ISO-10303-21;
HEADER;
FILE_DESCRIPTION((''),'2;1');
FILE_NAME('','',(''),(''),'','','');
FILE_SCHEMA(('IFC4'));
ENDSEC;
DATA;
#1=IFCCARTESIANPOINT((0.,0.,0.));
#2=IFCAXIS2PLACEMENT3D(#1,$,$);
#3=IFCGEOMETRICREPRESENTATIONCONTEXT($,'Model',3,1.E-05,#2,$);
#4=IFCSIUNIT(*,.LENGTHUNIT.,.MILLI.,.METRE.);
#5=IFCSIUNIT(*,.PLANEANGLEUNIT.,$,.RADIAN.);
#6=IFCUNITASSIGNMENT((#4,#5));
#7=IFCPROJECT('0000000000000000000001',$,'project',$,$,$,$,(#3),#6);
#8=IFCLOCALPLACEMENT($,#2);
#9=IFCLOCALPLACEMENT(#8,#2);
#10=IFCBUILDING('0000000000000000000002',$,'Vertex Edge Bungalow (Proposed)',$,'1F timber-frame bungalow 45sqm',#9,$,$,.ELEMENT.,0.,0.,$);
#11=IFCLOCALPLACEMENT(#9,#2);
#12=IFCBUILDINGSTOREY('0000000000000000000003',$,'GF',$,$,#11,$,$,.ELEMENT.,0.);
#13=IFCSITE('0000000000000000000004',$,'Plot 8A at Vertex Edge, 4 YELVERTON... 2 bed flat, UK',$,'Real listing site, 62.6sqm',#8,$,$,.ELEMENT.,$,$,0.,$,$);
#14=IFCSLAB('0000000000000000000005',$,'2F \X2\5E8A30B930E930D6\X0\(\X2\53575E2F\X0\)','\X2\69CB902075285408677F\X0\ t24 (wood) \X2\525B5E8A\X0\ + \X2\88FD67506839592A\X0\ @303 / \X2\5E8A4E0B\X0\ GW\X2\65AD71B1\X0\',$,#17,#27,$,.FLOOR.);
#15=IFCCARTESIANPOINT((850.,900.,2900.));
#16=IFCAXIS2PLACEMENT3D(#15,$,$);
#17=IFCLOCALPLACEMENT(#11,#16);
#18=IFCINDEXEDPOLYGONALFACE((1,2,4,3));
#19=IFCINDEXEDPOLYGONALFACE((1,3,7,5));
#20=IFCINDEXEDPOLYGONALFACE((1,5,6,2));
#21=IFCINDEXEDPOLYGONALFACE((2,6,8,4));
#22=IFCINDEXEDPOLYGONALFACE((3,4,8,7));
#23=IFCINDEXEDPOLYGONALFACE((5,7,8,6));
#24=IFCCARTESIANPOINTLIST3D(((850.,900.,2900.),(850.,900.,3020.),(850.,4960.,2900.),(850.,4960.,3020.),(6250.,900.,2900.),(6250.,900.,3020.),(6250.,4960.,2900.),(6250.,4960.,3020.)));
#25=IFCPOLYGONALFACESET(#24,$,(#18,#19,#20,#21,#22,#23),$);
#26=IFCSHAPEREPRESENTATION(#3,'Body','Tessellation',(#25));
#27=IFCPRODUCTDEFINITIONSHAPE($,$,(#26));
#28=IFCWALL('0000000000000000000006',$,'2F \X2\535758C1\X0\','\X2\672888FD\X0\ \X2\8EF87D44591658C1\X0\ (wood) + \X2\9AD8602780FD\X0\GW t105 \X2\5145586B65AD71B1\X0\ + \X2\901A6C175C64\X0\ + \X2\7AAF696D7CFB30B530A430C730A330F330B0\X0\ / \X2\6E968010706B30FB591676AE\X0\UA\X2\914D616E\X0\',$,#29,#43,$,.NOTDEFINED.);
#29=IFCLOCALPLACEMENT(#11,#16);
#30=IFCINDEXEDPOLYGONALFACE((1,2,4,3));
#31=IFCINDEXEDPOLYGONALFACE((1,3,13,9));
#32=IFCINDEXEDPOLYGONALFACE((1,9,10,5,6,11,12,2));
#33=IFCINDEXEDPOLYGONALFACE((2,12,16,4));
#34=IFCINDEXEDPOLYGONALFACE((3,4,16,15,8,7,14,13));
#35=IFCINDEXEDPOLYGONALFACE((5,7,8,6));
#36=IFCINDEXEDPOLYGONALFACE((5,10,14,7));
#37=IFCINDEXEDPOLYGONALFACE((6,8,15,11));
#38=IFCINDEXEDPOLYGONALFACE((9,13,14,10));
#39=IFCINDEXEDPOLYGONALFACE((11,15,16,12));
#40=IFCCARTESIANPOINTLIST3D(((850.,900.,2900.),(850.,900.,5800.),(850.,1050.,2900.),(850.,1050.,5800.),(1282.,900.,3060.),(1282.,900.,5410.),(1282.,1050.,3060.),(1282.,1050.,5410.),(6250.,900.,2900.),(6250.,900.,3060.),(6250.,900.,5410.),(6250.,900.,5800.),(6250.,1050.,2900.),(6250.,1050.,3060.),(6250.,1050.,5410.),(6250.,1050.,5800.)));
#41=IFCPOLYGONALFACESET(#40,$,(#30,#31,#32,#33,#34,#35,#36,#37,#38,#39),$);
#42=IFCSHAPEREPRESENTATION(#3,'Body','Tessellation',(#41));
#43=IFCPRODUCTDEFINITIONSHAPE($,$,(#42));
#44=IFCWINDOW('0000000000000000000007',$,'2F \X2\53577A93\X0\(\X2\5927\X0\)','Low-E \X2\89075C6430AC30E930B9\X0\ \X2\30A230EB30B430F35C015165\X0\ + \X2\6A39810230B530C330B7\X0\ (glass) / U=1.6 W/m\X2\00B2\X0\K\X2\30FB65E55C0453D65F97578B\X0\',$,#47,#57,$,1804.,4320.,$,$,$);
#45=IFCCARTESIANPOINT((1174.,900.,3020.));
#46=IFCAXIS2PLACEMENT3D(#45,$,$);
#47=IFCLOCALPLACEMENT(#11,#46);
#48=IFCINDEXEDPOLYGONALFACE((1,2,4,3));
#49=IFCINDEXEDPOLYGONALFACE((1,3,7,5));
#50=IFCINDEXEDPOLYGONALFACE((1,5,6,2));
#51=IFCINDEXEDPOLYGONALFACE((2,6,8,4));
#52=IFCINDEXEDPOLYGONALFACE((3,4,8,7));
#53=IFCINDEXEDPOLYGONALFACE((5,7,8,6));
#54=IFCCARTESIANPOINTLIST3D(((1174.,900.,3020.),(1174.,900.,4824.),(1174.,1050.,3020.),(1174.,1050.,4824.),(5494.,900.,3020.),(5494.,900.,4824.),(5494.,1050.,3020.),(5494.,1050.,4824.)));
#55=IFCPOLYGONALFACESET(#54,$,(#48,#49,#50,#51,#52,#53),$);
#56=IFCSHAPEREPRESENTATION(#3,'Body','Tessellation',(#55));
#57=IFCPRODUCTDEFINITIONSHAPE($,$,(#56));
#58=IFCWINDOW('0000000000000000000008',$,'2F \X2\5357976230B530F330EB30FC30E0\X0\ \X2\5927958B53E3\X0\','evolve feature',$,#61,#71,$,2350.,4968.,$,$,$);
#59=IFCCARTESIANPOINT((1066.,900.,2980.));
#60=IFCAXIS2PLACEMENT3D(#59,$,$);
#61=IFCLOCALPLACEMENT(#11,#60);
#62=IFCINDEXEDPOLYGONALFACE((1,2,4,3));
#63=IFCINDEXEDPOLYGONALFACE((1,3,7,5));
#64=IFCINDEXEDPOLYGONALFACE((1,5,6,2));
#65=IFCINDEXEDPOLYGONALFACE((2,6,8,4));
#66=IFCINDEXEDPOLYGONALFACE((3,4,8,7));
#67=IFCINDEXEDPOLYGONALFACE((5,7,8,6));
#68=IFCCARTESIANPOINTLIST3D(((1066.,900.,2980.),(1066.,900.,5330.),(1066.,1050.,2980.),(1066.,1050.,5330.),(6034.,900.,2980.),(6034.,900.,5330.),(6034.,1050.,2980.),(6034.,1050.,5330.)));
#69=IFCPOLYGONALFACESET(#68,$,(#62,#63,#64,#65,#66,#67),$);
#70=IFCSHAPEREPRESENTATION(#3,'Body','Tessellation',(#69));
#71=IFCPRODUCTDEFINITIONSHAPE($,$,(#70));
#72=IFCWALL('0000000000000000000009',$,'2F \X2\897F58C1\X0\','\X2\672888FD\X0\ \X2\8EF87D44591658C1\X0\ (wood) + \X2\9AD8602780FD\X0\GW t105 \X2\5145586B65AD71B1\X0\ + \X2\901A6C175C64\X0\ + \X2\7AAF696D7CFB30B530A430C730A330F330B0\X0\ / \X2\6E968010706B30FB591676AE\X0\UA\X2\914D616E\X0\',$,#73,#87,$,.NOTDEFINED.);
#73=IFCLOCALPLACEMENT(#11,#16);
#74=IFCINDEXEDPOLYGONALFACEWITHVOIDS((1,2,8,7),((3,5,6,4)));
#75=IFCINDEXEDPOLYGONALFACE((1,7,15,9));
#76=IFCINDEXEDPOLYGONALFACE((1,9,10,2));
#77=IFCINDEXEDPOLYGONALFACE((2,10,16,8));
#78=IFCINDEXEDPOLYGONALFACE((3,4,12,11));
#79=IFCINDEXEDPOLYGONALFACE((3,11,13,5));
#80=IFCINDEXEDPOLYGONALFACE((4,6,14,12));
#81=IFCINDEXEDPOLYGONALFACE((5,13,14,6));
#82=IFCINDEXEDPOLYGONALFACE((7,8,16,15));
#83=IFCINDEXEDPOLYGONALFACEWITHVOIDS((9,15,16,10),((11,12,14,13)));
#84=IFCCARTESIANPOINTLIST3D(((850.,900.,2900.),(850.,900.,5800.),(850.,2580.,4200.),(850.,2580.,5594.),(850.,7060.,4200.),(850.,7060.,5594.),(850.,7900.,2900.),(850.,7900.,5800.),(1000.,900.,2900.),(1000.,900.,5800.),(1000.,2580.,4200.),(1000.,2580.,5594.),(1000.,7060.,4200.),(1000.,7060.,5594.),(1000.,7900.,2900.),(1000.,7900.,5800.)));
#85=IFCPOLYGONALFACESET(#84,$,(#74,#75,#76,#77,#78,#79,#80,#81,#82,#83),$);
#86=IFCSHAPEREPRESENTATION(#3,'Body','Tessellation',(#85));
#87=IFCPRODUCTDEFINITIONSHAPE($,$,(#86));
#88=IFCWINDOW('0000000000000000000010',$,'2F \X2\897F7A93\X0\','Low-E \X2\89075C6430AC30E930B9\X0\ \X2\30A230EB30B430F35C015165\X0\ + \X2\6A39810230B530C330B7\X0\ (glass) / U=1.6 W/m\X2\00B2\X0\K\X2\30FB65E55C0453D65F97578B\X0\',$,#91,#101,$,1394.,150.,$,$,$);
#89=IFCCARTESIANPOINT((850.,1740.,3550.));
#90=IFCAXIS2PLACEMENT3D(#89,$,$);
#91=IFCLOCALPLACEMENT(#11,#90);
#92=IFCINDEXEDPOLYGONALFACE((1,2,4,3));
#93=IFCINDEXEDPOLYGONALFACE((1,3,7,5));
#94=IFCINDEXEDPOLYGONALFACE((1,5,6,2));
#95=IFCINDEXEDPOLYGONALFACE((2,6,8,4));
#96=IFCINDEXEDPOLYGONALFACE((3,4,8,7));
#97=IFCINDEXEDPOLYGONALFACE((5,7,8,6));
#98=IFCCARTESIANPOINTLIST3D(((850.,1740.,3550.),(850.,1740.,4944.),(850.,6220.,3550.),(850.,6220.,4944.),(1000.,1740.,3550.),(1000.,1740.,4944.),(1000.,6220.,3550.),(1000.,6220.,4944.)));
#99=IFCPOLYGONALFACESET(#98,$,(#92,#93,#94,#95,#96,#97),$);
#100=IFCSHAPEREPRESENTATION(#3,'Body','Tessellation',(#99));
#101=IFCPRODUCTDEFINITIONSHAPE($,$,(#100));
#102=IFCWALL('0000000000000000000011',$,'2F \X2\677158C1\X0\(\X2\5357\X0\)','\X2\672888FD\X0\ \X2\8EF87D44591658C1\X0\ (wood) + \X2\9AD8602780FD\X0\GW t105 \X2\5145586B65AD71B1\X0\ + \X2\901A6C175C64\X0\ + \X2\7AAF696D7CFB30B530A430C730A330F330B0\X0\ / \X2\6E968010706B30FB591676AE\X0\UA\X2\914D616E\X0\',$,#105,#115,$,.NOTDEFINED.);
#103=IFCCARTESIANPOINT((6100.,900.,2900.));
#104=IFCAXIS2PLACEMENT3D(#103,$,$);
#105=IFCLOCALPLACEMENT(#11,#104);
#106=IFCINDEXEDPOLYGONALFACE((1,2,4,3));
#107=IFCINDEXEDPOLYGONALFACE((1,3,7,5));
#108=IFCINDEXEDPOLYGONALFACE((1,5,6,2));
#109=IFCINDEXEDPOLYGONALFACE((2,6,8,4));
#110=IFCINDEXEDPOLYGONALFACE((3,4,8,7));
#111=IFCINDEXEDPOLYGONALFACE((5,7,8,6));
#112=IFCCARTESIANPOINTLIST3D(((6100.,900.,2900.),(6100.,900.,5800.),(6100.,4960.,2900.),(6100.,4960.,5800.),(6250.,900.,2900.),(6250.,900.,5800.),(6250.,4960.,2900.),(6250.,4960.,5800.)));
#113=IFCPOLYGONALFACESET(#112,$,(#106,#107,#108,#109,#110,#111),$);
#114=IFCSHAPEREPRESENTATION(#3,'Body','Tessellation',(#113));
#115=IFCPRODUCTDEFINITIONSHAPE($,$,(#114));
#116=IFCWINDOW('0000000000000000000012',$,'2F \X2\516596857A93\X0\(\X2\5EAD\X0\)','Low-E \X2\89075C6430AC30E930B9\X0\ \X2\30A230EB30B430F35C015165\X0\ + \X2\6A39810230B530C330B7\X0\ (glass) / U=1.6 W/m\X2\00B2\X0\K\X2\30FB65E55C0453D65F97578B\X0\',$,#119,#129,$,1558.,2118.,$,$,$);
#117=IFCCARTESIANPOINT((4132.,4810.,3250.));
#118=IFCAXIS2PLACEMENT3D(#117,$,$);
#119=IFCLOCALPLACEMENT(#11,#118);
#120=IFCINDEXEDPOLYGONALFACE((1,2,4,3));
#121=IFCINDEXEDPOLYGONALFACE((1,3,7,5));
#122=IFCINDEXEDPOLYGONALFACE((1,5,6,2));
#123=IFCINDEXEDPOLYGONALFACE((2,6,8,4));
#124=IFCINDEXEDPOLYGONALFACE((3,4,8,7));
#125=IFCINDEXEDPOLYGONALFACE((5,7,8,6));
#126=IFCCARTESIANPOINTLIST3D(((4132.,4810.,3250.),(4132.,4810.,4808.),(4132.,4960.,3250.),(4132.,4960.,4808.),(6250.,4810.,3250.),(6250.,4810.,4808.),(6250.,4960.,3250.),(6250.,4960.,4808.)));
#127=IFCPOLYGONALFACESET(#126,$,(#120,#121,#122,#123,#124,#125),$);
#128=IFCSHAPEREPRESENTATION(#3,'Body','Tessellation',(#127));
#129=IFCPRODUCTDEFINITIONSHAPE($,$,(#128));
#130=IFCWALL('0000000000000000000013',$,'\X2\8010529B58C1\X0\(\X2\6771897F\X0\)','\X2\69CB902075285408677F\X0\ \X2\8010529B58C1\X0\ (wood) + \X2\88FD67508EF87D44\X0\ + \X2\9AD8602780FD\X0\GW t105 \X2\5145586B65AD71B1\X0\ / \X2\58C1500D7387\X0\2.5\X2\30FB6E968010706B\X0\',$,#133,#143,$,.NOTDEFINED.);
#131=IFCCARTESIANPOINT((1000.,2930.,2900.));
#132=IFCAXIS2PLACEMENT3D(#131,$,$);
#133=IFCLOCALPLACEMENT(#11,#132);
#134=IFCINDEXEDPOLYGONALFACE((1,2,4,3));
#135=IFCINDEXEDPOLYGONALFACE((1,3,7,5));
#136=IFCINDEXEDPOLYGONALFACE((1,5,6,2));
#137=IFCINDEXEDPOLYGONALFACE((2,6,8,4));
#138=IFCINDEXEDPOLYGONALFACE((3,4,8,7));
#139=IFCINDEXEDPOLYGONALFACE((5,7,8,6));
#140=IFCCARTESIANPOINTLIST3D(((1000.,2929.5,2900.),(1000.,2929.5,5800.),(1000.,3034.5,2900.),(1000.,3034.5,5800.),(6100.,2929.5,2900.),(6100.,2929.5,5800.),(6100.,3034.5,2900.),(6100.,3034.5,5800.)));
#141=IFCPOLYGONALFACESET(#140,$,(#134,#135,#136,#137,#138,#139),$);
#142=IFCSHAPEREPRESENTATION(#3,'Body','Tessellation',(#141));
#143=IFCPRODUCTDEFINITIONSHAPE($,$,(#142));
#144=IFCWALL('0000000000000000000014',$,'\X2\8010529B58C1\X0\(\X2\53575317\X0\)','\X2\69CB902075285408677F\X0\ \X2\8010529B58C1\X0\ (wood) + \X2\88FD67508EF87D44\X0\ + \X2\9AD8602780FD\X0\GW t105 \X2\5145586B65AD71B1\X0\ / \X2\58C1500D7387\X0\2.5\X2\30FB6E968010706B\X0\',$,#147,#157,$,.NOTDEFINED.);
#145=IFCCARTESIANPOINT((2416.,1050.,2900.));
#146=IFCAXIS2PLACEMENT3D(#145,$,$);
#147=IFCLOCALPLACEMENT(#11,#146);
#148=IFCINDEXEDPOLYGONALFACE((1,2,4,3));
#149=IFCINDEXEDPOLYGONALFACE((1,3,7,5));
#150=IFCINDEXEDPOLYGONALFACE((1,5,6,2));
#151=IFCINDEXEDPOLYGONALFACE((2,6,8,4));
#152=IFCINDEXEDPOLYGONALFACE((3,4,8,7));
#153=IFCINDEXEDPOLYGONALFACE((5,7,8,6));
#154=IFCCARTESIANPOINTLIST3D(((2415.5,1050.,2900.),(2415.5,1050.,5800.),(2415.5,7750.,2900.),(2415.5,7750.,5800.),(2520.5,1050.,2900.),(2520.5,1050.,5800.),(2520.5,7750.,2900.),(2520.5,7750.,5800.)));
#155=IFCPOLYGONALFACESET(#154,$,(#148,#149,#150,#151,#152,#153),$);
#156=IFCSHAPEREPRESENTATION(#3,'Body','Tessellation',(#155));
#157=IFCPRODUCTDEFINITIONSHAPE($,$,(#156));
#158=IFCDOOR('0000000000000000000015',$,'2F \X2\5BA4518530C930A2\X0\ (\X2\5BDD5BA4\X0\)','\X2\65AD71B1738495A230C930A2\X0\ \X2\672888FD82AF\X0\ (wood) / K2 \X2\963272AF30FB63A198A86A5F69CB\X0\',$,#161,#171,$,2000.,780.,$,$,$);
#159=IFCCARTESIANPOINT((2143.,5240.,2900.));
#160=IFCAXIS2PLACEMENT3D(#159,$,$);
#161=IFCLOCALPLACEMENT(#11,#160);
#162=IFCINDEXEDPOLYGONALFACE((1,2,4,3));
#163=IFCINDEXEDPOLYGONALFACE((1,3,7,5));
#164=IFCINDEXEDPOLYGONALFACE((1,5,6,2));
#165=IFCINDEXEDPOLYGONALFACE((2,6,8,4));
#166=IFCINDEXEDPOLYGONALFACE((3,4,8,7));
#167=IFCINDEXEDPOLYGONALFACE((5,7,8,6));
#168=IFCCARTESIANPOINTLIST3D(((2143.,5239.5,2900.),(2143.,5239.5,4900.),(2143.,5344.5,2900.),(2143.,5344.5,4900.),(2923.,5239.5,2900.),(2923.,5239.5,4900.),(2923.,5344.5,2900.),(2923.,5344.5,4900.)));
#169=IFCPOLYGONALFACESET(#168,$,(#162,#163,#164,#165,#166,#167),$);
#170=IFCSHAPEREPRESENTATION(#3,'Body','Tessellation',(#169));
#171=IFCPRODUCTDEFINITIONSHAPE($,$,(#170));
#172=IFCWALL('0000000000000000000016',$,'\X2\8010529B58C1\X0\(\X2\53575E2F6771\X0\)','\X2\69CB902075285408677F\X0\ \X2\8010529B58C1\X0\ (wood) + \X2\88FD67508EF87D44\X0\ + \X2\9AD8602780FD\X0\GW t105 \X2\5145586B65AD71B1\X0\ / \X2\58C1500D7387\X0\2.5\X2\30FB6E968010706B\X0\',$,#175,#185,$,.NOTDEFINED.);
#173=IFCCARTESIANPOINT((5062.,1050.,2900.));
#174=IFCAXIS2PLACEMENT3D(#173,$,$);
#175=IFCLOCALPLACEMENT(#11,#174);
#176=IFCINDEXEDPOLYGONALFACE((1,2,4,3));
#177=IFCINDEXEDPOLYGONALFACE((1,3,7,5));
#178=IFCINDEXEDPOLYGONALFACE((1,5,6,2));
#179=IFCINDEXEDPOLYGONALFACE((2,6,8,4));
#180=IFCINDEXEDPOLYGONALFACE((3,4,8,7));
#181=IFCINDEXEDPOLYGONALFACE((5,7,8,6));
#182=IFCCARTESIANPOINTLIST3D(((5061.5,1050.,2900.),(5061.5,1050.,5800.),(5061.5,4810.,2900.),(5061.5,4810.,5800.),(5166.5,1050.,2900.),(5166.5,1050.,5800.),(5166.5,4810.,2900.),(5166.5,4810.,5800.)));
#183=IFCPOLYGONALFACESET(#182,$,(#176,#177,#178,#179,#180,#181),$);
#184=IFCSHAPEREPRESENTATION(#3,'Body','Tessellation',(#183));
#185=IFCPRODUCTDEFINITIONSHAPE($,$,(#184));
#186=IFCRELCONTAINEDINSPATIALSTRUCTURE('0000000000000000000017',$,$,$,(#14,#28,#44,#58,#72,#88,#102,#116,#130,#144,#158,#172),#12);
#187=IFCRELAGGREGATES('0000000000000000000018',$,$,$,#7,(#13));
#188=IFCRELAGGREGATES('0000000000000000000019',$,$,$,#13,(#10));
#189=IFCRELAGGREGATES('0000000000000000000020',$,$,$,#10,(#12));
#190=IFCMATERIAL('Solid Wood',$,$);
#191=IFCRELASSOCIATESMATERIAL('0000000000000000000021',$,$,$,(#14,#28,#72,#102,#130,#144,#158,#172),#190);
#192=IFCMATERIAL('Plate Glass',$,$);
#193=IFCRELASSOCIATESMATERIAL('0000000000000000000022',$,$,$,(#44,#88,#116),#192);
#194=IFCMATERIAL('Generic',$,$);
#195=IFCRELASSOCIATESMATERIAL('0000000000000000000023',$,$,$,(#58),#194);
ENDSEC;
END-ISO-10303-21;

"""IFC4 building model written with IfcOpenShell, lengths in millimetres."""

from ifc_helpers import new_model, si_unit, frame, frame_2d, origin, place, context, project, spatial, rectangle, extrude, material, element, fill, save


model = new_model("IFC4")

# Units and contexts
model_context = context("Model", 3, precision=1e-05, world=origin())
ifc_project = project(units=[si_unit("LENGTHUNIT", "METRE", prefix="MILLI"), si_unit("PLANEANGLEUNIT", "RADIAN")], contexts=[model_context])

# Site, building, storey
site_placement = place(None, origin())
site = spatial("IfcSite", under=ifc_project, at=site_placement, Name="Plot 8A at Vertex Edge, 4 YELVERTON... 2 bed flat, UK", ObjectType="Real listing site, 62.6sqm", CompositionType="ELEMENT", RefElevation=0.0)
building_placement = place(site_placement, origin())
building = spatial("IfcBuilding", under=site, at=building_placement, Name="Vertex Edge Bungalow (Proposed)", ObjectType="1F timber-frame bungalow 45sqm", CompositionType="ELEMENT", ElevationOfRefHeight=0.0, ElevationOfTerrain=0.0)
storey_placement = place(building_placement, origin())
storey = spatial("IfcBuildingStorey", under=building, at=storey_placement, Name="GF", CompositionType="ELEMENT", Elevation=0.0)

# Slab
ifc_material_1 = material(Name="Solid Wood")
slab_placement = place(storey_placement, frame((850.0, 900.0, 2900.0)))
element("IfcSlab", 1, at=slab_placement, inside=storey, material=ifc_material_1, Name="2F 床スラブ(南帯)", Description="構造用合板 t24 (wood) 剛床 + 製材根太 @303 / 床下 GW断熱", PredefinedType="FLOOR", context=model_context, shape_type="SweptSolid", body=[
    extrude(rectangle(XDim=5400.0, YDim=4060.0, at=frame_2d((2700.0, 2030.0))), frame((850.0, 900.0, 2900.0)), (0.0, 0.0, 1.0), 120.0),
])

# Wall, openings, windows
wall_1_placement = place(storey_placement, frame((850.0, 900.0, 2900.0)))
wall_1 = element("IfcWall", 2, at=wall_1_placement, inside=storey, material=ifc_material_1, Name="2F 南壁", Description="木製 軸組外壁 (wood) + 高性能GW t105 充填断熱 + 通気層 + 窯業系サイディング / 準耐火・外皮UA配慮", PredefinedType="NOTDEFINED", context=model_context, shape_type="SweptSolid", body=[
    extrude(rectangle(XDim=5400.0, YDim=150.0, at=frame_2d((2700.0, 75.0))), frame((850.0, 900.0, 2900.0)), (0.0, 0.0, 1.0), 2900.0),
])
opening_1_placement = place(storey_placement, frame((1174.0, 900.0, 3020.0)))
opening_1 = element("IfcOpeningElement", 3, at=opening_1_placement, cuts=wall_1, PredefinedType="NOTDEFINED", context=model_context, shape_type="SweptSolid", body=[
    extrude(rectangle(XDim=4320.0, YDim=150.0, at=frame_2d((2160.0, 75.0))), frame((1174.0, 900.0, 3020.0)), (0.0, 0.0, 1.0), 1804.0),
])
opening_2_placement = place(storey_placement, frame((1066.0, 900.0, 2980.0)))
opening_2 = element("IfcOpeningElement", 4, at=opening_2_placement, cuts=wall_1, PredefinedType="NOTDEFINED", context=model_context, shape_type="SweptSolid", body=[
    extrude(rectangle(XDim=4968.0, YDim=150.0, at=frame_2d((2484.0, 75.0))), frame((1066.0, 900.0, 2980.0)), (0.0, 0.0, 1.0), 2350.0),
])
ifc_material_2 = material(Name="Plate Glass")
window_1_placement = place(storey_placement, frame((1174.0, 900.0, 3020.0)))
window_1 = element("IfcWindow", 5, at=window_1_placement, inside=storey, material=ifc_material_2, Name="2F 南窓(大)", Description="Low-E 複層ガラス アルゴン封入 + 樹脂サッシ (glass) / U=1.6 W/m²K・日射取得型", OverallHeight=1804.0, OverallWidth=4320.0, context=model_context, shape_type="SweptSolid", body=[
    extrude(rectangle(XDim=4320.0, YDim=150.0, at=frame_2d((2160.0, 75.0))), frame((1174.0, 900.0, 3020.0)), (0.0, 0.0, 1.0), 1804.0),
])
fill(opening_1, window_1)
ifc_material_3 = material(Name="Generic")
window_2_placement = place(storey_placement, frame((1066.0, 900.0, 2980.0)))
window_2 = element("IfcWindow", 6, at=window_2_placement, inside=storey, material=ifc_material_3, Name="2F 南面サンルーム 大開口", Description="evolve feature", OverallHeight=2350.0, OverallWidth=4968.0, context=model_context, shape_type="SweptSolid", body=[
    extrude(rectangle(XDim=4968.0, YDim=150.0, at=frame_2d((2484.0, 75.0))), frame((1066.0, 900.0, 2980.0)), (0.0, 0.0, 1.0), 2350.0),
])
fill(opening_2, window_2)

# Walls, openings, windows
wall_2_placement = place(storey_placement, frame((850.0, 900.0, 2900.0)))
wall_2 = element("IfcWall", 7, at=wall_2_placement, inside=storey, material=ifc_material_1, Name="2F 西壁", Description="木製 軸組外壁 (wood) + 高性能GW t105 充填断熱 + 通気層 + 窯業系サイディング / 準耐火・外皮UA配慮", PredefinedType="NOTDEFINED", context=model_context, shape_type="SweptSolid", body=[
    extrude(rectangle(XDim=150.0, YDim=7000.0, at=frame_2d((75.0, 3500.0))), frame((850.0, 900.0, 2900.0)), (0.0, 0.0, 1.0), 2900.0),
])
opening_3_placement = place(storey_placement, frame((850.0, 1740.0, 3550.0)))
opening_3 = element("IfcOpeningElement", 8, at=opening_3_placement, cuts=wall_2, PredefinedType="NOTDEFINED", context=model_context, shape_type="SweptSolid", body=[
    extrude(rectangle(XDim=150.0, YDim=4480.0, at=frame_2d((75.0, 2240.0))), frame((850.0, 1740.0, 3550.0)), (0.0, 0.0, 1.0), 1394.0),
])
window_3_placement = place(storey_placement, frame((850.0, 1740.0, 3550.0)))
window_3 = element("IfcWindow", 9, at=window_3_placement, inside=storey, material=ifc_material_2, Name="2F 西窓", Description="Low-E 複層ガラス アルゴン封入 + 樹脂サッシ (glass) / U=1.6 W/m²K・日射取得型", OverallHeight=1394.0, OverallWidth=150.0, context=model_context, shape_type="SweptSolid", body=[
    extrude(rectangle(XDim=150.0, YDim=4480.0, at=frame_2d((75.0, 2240.0))), frame((850.0, 1740.0, 3550.0)), (0.0, 0.0, 1.0), 1394.0),
])
fill(opening_3, window_3)
wall_3_placement = place(storey_placement, frame((6100.0, 900.0, 2900.0)))
wall_3 = element("IfcWall", 10, at=wall_3_placement, inside=storey, material=ifc_material_1, Name="2F 東壁(南)", Description="木製 軸組外壁 (wood) + 高性能GW t105 充填断熱 + 通気層 + 窯業系サイディング / 準耐火・外皮UA配慮", PredefinedType="NOTDEFINED", context=model_context, shape_type="SweptSolid", body=[
    extrude(rectangle(XDim=150.0, YDim=4060.0, at=frame_2d((75.0, 2030.0))), frame((6100.0, 900.0, 2900.0)), (0.0, 0.0, 1.0), 2900.0),
])
opening_4_placement = place(storey_placement, frame((4132.0, 4810.0, 3250.0)))
opening_4 = element("IfcOpeningElement", 11, at=opening_4_placement, cuts=wall_3, PredefinedType="NOTDEFINED", context=model_context, shape_type="SweptSolid", body=[
    extrude(rectangle(XDim=2118.0, YDim=150.0, at=frame_2d((1059.0, 75.0))), frame((4132.0, 4810.0, 3250.0)), (0.0, 0.0, 1.0), 1558.0),
])
window_4_placement = place(storey_placement, frame((4132.0, 4810.0, 3250.0)))
window_4 = element("IfcWindow", 12, at=window_4_placement, inside=storey, material=ifc_material_2, Name="2F 入隅窓(庭)", Description="Low-E 複層ガラス アルゴン封入 + 樹脂サッシ (glass) / U=1.6 W/m²K・日射取得型", OverallHeight=1558.0, OverallWidth=2118.0, context=model_context, shape_type="SweptSolid", body=[
    extrude(rectangle(XDim=2118.0, YDim=150.0, at=frame_2d((1059.0, 75.0))), frame((4132.0, 4810.0, 3250.0)), (0.0, 0.0, 1.0), 1558.0),
])
fill(opening_4, window_4)

# Wall
wall_4_placement = place(storey_placement, frame((1000.0, 2930.0, 2900.0)))
element("IfcWall", 13, at=wall_4_placement, inside=storey, material=ifc_material_1, Name="耐力壁(東西)", Description="構造用合板 耐力壁 (wood) + 製材軸組 + 高性能GW t105 充填断熱 / 壁倍率2.5・準耐火", PredefinedType="NOTDEFINED", context=model_context, shape_type="SweptSolid", body=[
    extrude(rectangle(XDim=5100.0, YDim=105.0, at=frame_2d((2550.0, 52.0))), frame((1000.0, 2930.0, 2900.0)), (0.0, 0.0, 1.0), 2900.0),
])

# Wall, opening, door
wall_5_placement = place(storey_placement, frame((2416.0, 1050.0, 2900.0)))
wall_5 = element("IfcWall", 14, at=wall_5_placement, inside=storey, material=ifc_material_1, Name="耐力壁(南北)", Description="構造用合板 耐力壁 (wood) + 製材軸組 + 高性能GW t105 充填断熱 / 壁倍率2.5・準耐火", PredefinedType="NOTDEFINED", context=model_context, shape_type="SweptSolid", body=[
    extrude(rectangle(XDim=105.0, YDim=6700.0, at=frame_2d((52.0, 3350.0))), frame((2416.0, 1050.0, 2900.0)), (0.0, 0.0, 1.0), 2900.0),
])
opening_5_placement = place(storey_placement, frame((2143.0, 5240.0, 2900.0)))
opening_5 = element("IfcOpeningElement", 15, at=opening_5_placement, cuts=wall_5, PredefinedType="NOTDEFINED", context=model_context, shape_type="SweptSolid", body=[
    extrude(rectangle(XDim=780.0, YDim=105.0, at=frame_2d((390.0, 52.0))), frame((2143.0, 5240.0, 2900.0)), (0.0, 0.0, 1.0), 2000.0),
])
door_placement = place(storey_placement, frame((2143.0, 5240.0, 2900.0)))
door = element("IfcDoor", 16, at=door_placement, inside=storey, material=ifc_material_1, Name="2F 室内ドア (寝室)", Description="断熱玄関ドア 木製芯 (wood) / K2 防犯・採風機構", OverallHeight=2000.0, OverallWidth=780.0, context=model_context, shape_type="SweptSolid", body=[
    extrude(rectangle(XDim=780.0, YDim=105.0, at=frame_2d((390.0, 52.0))), frame((2143.0, 5240.0, 2900.0)), (0.0, 0.0, 1.0), 2000.0),
])
fill(opening_5, door)

# Wall
wall_6_placement = place(storey_placement, frame((5062.0, 1050.0, 2900.0)))
element("IfcWall", 17, at=wall_6_placement, inside=storey, material=ifc_material_1, Name="耐力壁(南帯東)", Description="構造用合板 耐力壁 (wood) + 製材軸組 + 高性能GW t105 充填断熱 / 壁倍率2.5・準耐火", PredefinedType="NOTDEFINED", context=model_context, shape_type="SweptSolid", body=[
    extrude(rectangle(XDim=105.0, YDim=3760.0, at=frame_2d((52.0, 1880.0))), frame((5062.0, 1050.0, 2900.0)), (0.0, 0.0, 1.0), 2900.0),
])

save(model, "model.ifc")
